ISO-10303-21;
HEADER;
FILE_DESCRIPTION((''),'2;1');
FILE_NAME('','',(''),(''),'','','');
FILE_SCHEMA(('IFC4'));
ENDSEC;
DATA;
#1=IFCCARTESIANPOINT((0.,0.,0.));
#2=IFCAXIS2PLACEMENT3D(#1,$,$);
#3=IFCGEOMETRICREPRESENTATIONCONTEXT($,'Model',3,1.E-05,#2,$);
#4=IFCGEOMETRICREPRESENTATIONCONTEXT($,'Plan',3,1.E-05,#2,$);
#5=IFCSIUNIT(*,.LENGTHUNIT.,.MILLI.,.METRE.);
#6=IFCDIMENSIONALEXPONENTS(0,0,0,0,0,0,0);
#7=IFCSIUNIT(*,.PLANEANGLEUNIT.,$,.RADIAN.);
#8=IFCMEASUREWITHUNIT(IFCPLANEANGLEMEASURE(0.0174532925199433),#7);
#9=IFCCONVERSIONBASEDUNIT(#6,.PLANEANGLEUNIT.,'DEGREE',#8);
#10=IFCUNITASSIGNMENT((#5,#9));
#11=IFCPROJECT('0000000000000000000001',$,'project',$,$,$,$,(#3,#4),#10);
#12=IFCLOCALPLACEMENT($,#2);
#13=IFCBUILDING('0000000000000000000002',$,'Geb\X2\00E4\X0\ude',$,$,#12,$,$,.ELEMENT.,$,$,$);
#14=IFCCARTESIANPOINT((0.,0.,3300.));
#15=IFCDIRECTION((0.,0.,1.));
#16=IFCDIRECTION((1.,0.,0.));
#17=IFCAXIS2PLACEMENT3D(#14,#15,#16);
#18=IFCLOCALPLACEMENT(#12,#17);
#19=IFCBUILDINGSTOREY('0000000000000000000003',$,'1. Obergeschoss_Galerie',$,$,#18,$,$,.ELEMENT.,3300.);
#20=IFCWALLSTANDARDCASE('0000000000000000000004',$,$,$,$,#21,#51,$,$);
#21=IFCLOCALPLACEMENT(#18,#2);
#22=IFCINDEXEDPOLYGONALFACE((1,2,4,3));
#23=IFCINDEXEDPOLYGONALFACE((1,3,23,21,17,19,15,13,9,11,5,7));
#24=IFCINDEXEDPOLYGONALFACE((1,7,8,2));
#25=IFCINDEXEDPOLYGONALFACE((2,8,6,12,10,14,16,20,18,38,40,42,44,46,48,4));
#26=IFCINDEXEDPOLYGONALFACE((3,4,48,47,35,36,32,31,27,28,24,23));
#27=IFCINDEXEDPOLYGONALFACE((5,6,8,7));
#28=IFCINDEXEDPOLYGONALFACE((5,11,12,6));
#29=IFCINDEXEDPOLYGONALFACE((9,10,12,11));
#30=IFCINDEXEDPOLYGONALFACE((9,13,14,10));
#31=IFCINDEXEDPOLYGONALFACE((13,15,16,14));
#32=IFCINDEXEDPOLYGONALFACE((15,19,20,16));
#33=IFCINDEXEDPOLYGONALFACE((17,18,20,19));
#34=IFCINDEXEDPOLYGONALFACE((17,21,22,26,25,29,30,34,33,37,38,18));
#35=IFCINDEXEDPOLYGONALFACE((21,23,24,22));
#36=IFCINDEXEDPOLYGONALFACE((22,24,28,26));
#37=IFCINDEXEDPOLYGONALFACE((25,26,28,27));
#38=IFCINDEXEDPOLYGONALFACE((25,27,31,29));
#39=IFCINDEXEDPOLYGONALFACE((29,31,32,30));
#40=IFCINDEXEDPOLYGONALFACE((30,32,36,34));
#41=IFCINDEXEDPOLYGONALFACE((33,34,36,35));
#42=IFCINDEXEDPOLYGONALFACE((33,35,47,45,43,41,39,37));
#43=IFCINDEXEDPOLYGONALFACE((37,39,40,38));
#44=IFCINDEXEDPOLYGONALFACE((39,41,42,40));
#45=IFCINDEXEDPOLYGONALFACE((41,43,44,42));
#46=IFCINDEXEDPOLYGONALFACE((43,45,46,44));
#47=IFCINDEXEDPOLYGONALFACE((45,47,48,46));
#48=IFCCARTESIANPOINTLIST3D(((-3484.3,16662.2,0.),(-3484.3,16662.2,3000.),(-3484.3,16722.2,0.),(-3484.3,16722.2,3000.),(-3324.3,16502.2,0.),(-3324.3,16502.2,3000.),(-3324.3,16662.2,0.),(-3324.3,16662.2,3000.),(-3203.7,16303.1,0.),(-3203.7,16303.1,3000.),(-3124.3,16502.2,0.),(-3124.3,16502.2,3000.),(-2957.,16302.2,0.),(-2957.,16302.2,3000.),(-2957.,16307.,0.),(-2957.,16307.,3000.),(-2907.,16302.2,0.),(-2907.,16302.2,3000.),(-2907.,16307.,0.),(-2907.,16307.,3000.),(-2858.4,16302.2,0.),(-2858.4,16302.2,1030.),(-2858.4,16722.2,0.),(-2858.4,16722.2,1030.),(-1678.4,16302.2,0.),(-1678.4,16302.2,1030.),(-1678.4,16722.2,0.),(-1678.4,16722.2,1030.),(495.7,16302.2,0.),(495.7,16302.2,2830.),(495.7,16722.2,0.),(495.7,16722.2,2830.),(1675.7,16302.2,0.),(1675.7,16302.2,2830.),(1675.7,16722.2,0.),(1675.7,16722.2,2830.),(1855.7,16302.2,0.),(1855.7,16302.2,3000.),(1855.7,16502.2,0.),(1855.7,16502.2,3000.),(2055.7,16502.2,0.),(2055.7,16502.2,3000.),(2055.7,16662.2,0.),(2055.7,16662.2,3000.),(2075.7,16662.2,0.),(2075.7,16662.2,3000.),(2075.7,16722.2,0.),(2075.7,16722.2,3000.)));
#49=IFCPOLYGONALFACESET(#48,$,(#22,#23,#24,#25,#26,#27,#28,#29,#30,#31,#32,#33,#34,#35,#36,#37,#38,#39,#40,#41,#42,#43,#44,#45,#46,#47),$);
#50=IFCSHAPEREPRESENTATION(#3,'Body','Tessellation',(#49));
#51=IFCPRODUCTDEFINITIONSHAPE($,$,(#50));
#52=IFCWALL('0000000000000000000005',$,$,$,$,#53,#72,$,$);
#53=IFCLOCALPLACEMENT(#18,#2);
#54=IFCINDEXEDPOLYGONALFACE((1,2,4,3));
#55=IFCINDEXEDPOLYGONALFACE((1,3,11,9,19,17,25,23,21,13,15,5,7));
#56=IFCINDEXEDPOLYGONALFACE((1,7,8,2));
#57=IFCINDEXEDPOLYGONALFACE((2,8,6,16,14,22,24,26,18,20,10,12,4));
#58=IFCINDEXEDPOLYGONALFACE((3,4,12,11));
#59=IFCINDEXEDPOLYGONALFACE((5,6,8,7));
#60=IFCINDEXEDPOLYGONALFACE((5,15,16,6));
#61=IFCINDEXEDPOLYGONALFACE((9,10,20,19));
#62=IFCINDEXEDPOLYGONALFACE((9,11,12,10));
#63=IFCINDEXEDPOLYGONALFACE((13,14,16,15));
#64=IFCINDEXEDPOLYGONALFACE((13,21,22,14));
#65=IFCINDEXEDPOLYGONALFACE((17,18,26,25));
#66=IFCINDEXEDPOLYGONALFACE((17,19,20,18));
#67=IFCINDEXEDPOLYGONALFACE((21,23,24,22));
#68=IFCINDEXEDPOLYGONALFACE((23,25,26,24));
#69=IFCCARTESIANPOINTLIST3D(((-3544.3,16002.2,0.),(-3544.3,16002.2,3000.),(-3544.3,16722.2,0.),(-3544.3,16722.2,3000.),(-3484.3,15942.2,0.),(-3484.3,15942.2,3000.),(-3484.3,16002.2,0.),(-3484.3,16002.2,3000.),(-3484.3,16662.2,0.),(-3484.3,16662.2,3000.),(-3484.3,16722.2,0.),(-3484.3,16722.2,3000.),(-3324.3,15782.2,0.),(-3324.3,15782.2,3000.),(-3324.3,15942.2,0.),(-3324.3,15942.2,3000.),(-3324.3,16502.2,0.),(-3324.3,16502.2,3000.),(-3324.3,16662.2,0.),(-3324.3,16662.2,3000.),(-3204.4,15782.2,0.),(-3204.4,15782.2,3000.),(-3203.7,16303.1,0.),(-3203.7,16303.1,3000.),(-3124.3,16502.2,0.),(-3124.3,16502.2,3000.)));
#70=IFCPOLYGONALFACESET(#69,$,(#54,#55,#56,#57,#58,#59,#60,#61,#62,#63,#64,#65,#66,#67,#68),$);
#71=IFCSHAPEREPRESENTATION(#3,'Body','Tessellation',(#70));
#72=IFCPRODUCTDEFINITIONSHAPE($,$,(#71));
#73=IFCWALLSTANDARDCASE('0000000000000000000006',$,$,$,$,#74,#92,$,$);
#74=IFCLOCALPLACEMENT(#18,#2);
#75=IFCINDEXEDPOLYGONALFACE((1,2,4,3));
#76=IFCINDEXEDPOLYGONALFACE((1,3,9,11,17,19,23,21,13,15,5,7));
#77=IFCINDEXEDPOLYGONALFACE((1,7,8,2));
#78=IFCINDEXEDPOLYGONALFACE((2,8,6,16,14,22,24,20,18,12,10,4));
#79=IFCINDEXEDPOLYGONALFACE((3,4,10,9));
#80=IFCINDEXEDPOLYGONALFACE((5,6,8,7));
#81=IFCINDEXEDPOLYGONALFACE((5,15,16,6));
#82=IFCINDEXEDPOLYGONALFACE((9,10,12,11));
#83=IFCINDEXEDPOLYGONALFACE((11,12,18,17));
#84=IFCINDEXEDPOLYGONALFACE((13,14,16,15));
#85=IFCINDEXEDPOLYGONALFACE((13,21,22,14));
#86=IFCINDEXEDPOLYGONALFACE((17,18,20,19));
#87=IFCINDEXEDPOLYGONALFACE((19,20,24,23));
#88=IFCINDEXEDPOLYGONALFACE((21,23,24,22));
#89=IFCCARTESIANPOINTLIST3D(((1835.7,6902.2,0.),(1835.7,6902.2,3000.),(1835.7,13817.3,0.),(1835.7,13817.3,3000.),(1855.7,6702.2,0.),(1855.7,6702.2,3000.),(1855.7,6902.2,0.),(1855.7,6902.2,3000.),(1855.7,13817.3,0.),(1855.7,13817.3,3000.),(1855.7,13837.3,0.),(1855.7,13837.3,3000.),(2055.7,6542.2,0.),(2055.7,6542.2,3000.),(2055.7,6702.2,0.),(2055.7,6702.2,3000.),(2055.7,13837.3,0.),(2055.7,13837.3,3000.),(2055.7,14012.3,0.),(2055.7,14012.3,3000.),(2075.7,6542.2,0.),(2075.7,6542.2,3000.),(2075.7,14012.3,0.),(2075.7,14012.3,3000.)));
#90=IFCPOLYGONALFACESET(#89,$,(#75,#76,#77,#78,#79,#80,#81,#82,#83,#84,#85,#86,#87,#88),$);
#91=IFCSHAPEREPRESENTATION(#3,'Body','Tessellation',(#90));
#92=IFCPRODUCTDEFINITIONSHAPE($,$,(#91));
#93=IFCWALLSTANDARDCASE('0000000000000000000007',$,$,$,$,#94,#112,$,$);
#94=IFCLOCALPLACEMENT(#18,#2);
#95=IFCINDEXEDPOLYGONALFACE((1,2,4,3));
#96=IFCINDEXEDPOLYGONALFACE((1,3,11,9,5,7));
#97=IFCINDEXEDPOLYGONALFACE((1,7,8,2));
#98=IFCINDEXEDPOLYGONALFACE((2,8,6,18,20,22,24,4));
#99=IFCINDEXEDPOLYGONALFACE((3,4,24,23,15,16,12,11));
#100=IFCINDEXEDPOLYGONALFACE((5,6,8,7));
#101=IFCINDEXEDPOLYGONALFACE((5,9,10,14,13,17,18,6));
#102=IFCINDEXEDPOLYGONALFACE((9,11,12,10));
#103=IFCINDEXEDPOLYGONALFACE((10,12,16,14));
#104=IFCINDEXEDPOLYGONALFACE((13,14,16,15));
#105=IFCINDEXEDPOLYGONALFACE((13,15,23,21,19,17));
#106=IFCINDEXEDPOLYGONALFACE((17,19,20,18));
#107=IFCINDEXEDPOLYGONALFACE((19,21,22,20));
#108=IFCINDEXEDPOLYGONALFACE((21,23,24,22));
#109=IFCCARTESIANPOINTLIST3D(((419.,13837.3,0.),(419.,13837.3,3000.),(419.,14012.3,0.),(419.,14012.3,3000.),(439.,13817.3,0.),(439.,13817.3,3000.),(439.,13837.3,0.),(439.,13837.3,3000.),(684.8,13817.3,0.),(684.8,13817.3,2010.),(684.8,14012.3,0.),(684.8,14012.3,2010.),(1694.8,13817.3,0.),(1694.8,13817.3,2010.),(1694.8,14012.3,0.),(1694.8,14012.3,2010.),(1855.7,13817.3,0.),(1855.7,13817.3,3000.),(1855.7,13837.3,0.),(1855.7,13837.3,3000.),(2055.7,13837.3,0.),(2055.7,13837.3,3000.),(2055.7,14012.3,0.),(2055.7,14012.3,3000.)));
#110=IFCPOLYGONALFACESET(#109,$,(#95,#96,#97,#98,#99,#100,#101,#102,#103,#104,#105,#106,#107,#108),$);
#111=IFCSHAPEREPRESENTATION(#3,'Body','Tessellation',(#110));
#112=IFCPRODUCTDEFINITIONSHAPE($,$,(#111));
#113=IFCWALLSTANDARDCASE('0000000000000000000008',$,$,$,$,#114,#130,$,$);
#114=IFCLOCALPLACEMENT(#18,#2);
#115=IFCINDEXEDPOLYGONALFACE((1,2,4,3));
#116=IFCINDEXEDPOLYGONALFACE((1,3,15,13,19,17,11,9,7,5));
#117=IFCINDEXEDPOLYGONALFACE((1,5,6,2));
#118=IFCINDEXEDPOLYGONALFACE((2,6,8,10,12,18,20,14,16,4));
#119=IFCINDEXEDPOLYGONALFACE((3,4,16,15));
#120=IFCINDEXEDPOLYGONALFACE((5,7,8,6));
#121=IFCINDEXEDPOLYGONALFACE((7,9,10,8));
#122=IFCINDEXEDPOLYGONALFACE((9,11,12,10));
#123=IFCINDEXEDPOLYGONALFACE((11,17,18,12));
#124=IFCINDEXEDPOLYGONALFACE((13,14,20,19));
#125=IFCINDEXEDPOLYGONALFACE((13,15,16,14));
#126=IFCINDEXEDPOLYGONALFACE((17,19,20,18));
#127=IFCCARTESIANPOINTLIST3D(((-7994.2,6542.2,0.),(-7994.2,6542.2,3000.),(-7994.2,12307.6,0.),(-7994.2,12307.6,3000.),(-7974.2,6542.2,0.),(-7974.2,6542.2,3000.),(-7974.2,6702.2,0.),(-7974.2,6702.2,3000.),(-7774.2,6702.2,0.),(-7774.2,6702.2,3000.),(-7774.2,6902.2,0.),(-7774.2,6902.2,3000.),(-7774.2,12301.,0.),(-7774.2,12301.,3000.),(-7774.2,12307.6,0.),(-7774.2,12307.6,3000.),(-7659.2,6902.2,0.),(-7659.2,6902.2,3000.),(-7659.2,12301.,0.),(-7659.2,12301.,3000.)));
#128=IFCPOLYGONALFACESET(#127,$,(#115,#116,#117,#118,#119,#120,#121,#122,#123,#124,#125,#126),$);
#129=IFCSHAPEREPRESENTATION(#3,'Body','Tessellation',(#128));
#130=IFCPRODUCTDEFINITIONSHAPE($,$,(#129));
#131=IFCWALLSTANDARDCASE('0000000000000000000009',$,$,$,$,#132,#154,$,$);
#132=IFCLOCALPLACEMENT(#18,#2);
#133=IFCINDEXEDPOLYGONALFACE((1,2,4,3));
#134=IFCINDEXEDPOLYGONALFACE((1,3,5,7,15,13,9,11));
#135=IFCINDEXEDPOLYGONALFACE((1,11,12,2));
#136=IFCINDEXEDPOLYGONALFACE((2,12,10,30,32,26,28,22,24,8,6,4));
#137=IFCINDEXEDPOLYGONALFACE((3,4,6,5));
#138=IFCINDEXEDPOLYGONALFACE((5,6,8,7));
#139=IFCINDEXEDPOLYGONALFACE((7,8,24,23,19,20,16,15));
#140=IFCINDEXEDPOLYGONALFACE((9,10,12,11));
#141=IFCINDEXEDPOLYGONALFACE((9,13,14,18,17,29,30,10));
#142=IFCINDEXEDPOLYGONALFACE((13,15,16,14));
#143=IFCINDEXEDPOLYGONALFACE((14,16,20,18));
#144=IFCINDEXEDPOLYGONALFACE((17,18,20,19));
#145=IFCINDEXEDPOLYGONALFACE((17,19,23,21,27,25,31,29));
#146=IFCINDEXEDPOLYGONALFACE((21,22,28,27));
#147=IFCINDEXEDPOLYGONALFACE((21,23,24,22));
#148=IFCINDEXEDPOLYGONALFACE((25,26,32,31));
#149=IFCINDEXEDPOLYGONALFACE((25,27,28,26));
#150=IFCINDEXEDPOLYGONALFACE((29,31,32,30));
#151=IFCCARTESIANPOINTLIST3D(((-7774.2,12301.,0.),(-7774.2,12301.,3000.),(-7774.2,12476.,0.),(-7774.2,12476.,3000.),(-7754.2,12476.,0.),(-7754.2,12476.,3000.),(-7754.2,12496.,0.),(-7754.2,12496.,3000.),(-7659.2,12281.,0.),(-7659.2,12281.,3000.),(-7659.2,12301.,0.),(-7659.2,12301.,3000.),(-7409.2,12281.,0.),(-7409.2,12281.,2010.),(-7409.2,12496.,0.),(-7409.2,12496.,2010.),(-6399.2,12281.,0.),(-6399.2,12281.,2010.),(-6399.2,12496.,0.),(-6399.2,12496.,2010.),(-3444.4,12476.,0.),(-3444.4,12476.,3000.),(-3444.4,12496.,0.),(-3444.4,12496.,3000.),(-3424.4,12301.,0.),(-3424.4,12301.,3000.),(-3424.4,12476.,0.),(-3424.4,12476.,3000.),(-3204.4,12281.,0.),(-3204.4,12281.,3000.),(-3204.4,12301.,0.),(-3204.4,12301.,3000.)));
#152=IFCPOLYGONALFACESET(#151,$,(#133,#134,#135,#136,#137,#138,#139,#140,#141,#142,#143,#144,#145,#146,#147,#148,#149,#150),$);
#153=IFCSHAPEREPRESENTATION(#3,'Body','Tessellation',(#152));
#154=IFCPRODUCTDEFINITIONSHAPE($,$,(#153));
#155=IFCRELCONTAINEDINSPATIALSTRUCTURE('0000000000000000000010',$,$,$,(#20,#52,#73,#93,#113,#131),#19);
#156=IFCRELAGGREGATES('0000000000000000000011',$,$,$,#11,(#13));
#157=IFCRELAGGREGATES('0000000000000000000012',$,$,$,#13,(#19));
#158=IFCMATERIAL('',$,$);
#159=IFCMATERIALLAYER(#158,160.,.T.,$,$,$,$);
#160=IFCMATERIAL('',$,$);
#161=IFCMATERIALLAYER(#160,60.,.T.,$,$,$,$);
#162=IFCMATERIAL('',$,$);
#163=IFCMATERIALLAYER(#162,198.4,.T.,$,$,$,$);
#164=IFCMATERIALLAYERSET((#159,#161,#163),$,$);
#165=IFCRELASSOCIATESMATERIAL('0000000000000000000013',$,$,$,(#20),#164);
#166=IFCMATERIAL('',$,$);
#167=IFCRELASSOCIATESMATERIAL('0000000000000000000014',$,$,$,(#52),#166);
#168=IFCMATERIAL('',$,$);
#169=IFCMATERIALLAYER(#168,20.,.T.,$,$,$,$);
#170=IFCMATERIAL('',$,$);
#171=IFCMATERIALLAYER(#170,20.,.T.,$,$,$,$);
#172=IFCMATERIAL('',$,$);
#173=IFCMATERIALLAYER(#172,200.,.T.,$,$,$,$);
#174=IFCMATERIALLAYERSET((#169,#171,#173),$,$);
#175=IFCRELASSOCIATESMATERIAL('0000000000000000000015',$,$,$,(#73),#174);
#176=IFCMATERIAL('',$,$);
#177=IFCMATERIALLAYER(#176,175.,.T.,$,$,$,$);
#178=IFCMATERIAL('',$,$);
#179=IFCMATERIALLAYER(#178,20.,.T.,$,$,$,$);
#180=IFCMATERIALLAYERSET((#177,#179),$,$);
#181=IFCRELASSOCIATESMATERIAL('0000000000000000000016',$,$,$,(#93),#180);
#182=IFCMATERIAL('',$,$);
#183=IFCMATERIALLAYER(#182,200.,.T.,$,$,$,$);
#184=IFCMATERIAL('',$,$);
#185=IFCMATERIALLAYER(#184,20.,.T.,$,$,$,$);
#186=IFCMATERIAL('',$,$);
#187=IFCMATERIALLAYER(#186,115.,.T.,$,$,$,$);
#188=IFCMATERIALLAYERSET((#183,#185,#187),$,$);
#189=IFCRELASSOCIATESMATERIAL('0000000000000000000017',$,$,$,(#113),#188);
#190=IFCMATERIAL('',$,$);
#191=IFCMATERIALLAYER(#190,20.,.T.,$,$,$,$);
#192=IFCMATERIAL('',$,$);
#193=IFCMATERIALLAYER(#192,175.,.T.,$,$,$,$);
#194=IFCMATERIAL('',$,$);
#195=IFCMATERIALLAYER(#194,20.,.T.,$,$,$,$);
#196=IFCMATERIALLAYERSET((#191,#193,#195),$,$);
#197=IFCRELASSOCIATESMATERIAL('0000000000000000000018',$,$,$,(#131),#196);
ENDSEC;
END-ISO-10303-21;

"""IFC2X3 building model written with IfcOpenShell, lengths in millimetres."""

from ifc_helpers import new_model, entity, si_unit, converted_unit, frame, frame_2d, origin, origin_with_axes, place, context, project, spatial, polyline, rectangle, outline, extrude, material, layer, layer_set, layer_usage, element, save


model = new_model("IFC2X3")

# Units and contexts
model_context = context("Model", 3, precision=1e-05, world=origin())
plan_context = context("Plan", 3, precision=1e-05, world=origin())
ifc_project = project(units=[si_unit("LENGTHUNIT", "METRE", prefix="MILLI"), converted_unit("PLANEANGLEUNIT", "DEGREE", entity("IfcPlaneAngleMeasure", 0.0174532925199433), si_unit("PLANEANGLEUNIT", "RADIAN"), dimensions=[0, 0, 0, 0, 0, 0, 0])], contexts=[model_context, plan_context])

# Building, storey
building_placement = place(None, origin())
building = spatial("IfcBuilding", under=ifc_project, at=building_placement, Name="Gebäude", CompositionType="ELEMENT")
storey_placement = place(building_placement, frame((0.0, 0.0, 3300.0), z_axis=(0.0, 0.0, 1.0), x_axis=(1.0, 0.0, 0.0)))
storey = spatial("IfcBuildingStorey", under=building, at=storey_placement, Name="1. Obergeschoss_Galerie", CompositionType="ELEMENT", Elevation=3300.0)

# Wall, openings
ifc_material_1 = material(Name="")
ifc_layer_1 = layer(ifc_material_1, 160.0, ventilated=True)
ifc_material_2 = material(Name="")
ifc_layer_2 = layer(ifc_material_2, 60.0, ventilated=True)
ifc_material_3 = material(Name="")
ifc_layer_3 = layer(ifc_material_3, 198.4, ventilated=True)
ifc_layer_set_1 = layer_set([ifc_layer_1, ifc_layer_2, ifc_layer_3])
ifc_layer_usage_1 = layer_usage(ifc_layer_set_1, "AXIS2", "POSITIVE", 0.0)
wall_1_placement = place(storey_placement, frame((2075.7, 16722.2, 0.0), z_axis=(0.0, 0.0, 1.0), x_axis=(-1.0, 0.0, 0.0)))
wall_1 = element("IfcWallStandardCase", 1, at=wall_1_placement, inside=storey, material=ifc_layer_usage_1, context=model_context, shape_type="SweptSolid", body=[
    extrude(outline(polyline([(0.0, 0.0), (5560.0, 0.0), (5560.0, 60.0), (5400.0, 60.0), (5400.0, 220.0), (5200.0, 220.0), (5279.5, 419.2), (5032.7, 420.0), (5032.7, 415.3), (4982.7, 415.3), (4982.7, 420.0), (220.0, 420.0), (220.0, 220.0), (20.0, 220.0), (20.0, 60.0), (0.0, 60.0), (0.0, 0.0)])), origin_with_axes(), (0.0, 0.0, 1.0), 3000.0),
])
opening_1_placement = place(wall_1_placement, frame((3754.1, 0.0, 0.0), z_axis=(0.0, 1.0, 0.0), x_axis=(0.0, 0.0, 1.0)))
element("IfcOpeningElement", 2, at=opening_1_placement, cuts=wall_1, ObjectType="Opening", context=model_context, shape_type="SweptSolid", body=[
    extrude(rectangle(XDim=1030.0, YDim=1180.0, at=frame_2d((515.0, 590.0), x_axis=(1.0, 0.0))), origin_with_axes(), (0.0, 0.0, 1.0), 420.0),
])
opening_2_placement = place(wall_1_placement, frame((400.0, 0.0, 0.0), z_axis=(0.0, 1.0, 0.0), x_axis=(0.0, 0.0, 1.0)))
element("IfcOpeningElement", 3, at=opening_2_placement, cuts=wall_1, ObjectType="Opening", context=model_context, shape_type="SweptSolid", body=[
    extrude(rectangle(XDim=2830.0, YDim=1180.0, at=frame_2d((1415.0, 590.0), x_axis=(1.0, 0.0))), origin_with_axes(), (0.0, 0.0, 1.0), 420.0),
])

# Walls
ifc_material_4 = material(Name="")
wall_2_placement = place(storey_placement, frame((-3544.3, 16722.2, 0.0), z_axis=(0.0, 0.0, 1.0), x_axis=(0.0, -1.0, 0.0)))
element("IfcWall", 4, at=wall_2_placement, inside=storey, material=ifc_material_4, context=model_context, shape_type="SweptSolid", body=[
    extrude(outline(polyline([(0.0, 0.0), (720.0, 0.0), (720.0, 60.0), (780.0, 60.0), (780.0, 220.0), (940.0, 220.0), (940.0, 339.8), (419.2, 340.5), (220.0, 420.0), (220.0, 220.0), (60.0, 220.0), (60.0, 60.0), (0.0, 60.0), (0.0, 0.0)])), origin_with_axes(), (0.0, 0.0, 1.0), 3000.0),
])
ifc_material_5 = material(Name="")
ifc_layer_4 = layer(ifc_material_5, 20.0, ventilated=True)
ifc_material_6 = material(Name="")
ifc_layer_5 = layer(ifc_material_6, 20.0, ventilated=True)
ifc_material_7 = material(Name="")
ifc_layer_6 = layer(ifc_material_7, 200.0, ventilated=True)
ifc_layer_set_2 = layer_set([ifc_layer_4, ifc_layer_5, ifc_layer_6])
ifc_layer_usage_2 = layer_usage(ifc_layer_set_2, "AXIS2", "POSITIVE", 0.0)
wall_3_placement = place(storey_placement, frame((2075.7, 6542.2, 0.0), z_axis=(0.0, 0.0, 1.0), x_axis=(0.0, 1.0, 0.0)))
element("IfcWallStandardCase", 5, at=wall_3_placement, inside=storey, material=ifc_layer_usage_2, context=model_context, shape_type="SweptSolid", body=[
    extrude(outline(polyline([(0.0, 0.0), (7470.1, 0.0), (7470.1, 20.0), (7295.1, 20.0), (7295.1, 220.0), (7275.1, 220.0), (7275.1, 240.0), (360.0, 240.0), (360.0, 220.0), (160.0, 220.0), (160.0, 20.0), (0.0, 20.0), (0.0, 0.0)])), origin_with_axes(), (0.0, 0.0, 1.0), 3000.0),
])

# Wall, opening
ifc_material_8 = material(Name="")
ifc_layer_7 = layer(ifc_material_8, 175.0, ventilated=True)
ifc_material_9 = material(Name="")
ifc_layer_8 = layer(ifc_material_9, 20.0, ventilated=True)
ifc_layer_set_3 = layer_set([ifc_layer_7, ifc_layer_8])
ifc_layer_usage_3 = layer_usage(ifc_layer_set_3, "AXIS2", "POSITIVE", 0.0)
wall_4_placement = place(storey_placement, frame((2055.7, 14012.3, 0.0), z_axis=(0.0, 0.0, 1.0), x_axis=(-1.0, 0.0, 0.0)))
wall_4 = element("IfcWallStandardCase", 6, at=wall_4_placement, inside=storey, material=ifc_layer_usage_3, context=model_context, shape_type="SweptSolid", body=[
    extrude(outline(polyline([(0.0, 0.0), (1636.8, 0.0), (1636.8, 175.0), (1616.8, 175.0), (1616.8, 195.0), (200.0, 195.0), (200.0, 175.0), (0.0, 175.0), (0.0, 0.0)])), origin_with_axes(), (0.0, 0.0, 1.0), 3000.0),
])
opening_3_placement = place(wall_4_placement, frame((360.9, 0.0, 0.0), z_axis=(0.0, 1.0, 0.0), x_axis=(0.0, 0.0, 1.0)))
element("IfcOpeningElement", 7, at=opening_3_placement, cuts=wall_4, ObjectType="Opening", context=model_context, shape_type="SweptSolid", body=[
    extrude(rectangle(XDim=2010.0, YDim=1010.0, at=frame_2d((1005.0, 505.0), x_axis=(1.0, 0.0))), origin_with_axes(), (0.0, 0.0, 1.0), 195.0),
])

# Wall
ifc_material_10 = material(Name="")
ifc_layer_9 = layer(ifc_material_10, 200.0, ventilated=True)
ifc_material_11 = material(Name="")
ifc_layer_10 = layer(ifc_material_11, 20.0, ventilated=True)
ifc_material_12 = material(Name="")
ifc_layer_11 = layer(ifc_material_12, 115.0, ventilated=True)
ifc_layer_set_4 = layer_set([ifc_layer_9, ifc_layer_10, ifc_layer_11])
ifc_layer_usage_4 = layer_usage(ifc_layer_set_4, "AXIS2", "POSITIVE", 0.0)
wall_5_placement = place(storey_placement, frame((-7994.2, 12307.6, 0.0), z_axis=(0.0, 0.0, 1.0), x_axis=(0.0, -1.0, 0.0)))
element("IfcWallStandardCase", 8, at=wall_5_placement, inside=storey, material=ifc_layer_usage_4, context=model_context, shape_type="SweptSolid", body=[
    extrude(outline(polyline([(0.0, 0.0), (5765.4, 0.0), (5765.4, 20.0), (5605.4, 20.0), (5605.4, 220.0), (5405.4, 220.0), (5405.4, 335.0), (6.6, 335.0), (6.6, 220.0), (0.0, 220.0), (0.0, 0.0)])), origin_with_axes(), (0.0, 0.0, 1.0), 3000.0),
])

# Wall, opening
ifc_material_13 = material(Name="")
ifc_layer_12 = layer(ifc_material_13, 20.0, ventilated=True)
ifc_material_14 = material(Name="")
ifc_layer_13 = layer(ifc_material_14, 175.0, ventilated=True)
ifc_material_15 = material(Name="")
ifc_layer_14 = layer(ifc_material_15, 20.0, ventilated=True)
ifc_layer_set_5 = layer_set([ifc_layer_12, ifc_layer_13, ifc_layer_14])
ifc_layer_usage_5 = layer_usage(ifc_layer_set_5, "AXIS2", "POSITIVE", 0.0)
wall_6_placement = place(storey_placement, frame((-7659.2, 12281.0, 0.0), z_axis=(0.0, 0.0, 1.0), x_axis=(1.0, 0.0, 0.0)))
wall_6 = element("IfcWallStandardCase", 9, at=wall_6_placement, inside=storey, material=ifc_layer_usage_5, context=model_context, shape_type="SweptSolid", body=[
    extrude(outline(polyline([(0.0, 0.0), (4454.8, 0.0), (4454.8, 20.0), (4234.8, 20.0), (4234.8, 195.0), (4214.8, 195.0), (4214.8, 215.0), (-95.0, 215.0), (-95.0, 195.0), (-115.0, 195.0), (-115.0, 20.0), (0.0, 20.0), (0.0, 0.0)])), origin_with_axes(), (0.0, 0.0, 1.0), 3000.0),
])
opening_4_placement = place(wall_6_placement, frame((250.0, 0.0, 0.0), z_axis=(0.0, 1.0, 0.0), x_axis=(0.0, 0.0, 1.0)))
element("IfcOpeningElement", 10, at=opening_4_placement, cuts=wall_6, ObjectType="Opening", context=model_context, shape_type="SweptSolid", body=[
    extrude(rectangle(XDim=2010.0, YDim=1010.0, at=frame_2d((1005.0, 505.0), x_axis=(1.0, 0.0))), origin_with_axes(), (0.0, 0.0, 1.0), 215.0),
])

save(model, "model.ifc")
